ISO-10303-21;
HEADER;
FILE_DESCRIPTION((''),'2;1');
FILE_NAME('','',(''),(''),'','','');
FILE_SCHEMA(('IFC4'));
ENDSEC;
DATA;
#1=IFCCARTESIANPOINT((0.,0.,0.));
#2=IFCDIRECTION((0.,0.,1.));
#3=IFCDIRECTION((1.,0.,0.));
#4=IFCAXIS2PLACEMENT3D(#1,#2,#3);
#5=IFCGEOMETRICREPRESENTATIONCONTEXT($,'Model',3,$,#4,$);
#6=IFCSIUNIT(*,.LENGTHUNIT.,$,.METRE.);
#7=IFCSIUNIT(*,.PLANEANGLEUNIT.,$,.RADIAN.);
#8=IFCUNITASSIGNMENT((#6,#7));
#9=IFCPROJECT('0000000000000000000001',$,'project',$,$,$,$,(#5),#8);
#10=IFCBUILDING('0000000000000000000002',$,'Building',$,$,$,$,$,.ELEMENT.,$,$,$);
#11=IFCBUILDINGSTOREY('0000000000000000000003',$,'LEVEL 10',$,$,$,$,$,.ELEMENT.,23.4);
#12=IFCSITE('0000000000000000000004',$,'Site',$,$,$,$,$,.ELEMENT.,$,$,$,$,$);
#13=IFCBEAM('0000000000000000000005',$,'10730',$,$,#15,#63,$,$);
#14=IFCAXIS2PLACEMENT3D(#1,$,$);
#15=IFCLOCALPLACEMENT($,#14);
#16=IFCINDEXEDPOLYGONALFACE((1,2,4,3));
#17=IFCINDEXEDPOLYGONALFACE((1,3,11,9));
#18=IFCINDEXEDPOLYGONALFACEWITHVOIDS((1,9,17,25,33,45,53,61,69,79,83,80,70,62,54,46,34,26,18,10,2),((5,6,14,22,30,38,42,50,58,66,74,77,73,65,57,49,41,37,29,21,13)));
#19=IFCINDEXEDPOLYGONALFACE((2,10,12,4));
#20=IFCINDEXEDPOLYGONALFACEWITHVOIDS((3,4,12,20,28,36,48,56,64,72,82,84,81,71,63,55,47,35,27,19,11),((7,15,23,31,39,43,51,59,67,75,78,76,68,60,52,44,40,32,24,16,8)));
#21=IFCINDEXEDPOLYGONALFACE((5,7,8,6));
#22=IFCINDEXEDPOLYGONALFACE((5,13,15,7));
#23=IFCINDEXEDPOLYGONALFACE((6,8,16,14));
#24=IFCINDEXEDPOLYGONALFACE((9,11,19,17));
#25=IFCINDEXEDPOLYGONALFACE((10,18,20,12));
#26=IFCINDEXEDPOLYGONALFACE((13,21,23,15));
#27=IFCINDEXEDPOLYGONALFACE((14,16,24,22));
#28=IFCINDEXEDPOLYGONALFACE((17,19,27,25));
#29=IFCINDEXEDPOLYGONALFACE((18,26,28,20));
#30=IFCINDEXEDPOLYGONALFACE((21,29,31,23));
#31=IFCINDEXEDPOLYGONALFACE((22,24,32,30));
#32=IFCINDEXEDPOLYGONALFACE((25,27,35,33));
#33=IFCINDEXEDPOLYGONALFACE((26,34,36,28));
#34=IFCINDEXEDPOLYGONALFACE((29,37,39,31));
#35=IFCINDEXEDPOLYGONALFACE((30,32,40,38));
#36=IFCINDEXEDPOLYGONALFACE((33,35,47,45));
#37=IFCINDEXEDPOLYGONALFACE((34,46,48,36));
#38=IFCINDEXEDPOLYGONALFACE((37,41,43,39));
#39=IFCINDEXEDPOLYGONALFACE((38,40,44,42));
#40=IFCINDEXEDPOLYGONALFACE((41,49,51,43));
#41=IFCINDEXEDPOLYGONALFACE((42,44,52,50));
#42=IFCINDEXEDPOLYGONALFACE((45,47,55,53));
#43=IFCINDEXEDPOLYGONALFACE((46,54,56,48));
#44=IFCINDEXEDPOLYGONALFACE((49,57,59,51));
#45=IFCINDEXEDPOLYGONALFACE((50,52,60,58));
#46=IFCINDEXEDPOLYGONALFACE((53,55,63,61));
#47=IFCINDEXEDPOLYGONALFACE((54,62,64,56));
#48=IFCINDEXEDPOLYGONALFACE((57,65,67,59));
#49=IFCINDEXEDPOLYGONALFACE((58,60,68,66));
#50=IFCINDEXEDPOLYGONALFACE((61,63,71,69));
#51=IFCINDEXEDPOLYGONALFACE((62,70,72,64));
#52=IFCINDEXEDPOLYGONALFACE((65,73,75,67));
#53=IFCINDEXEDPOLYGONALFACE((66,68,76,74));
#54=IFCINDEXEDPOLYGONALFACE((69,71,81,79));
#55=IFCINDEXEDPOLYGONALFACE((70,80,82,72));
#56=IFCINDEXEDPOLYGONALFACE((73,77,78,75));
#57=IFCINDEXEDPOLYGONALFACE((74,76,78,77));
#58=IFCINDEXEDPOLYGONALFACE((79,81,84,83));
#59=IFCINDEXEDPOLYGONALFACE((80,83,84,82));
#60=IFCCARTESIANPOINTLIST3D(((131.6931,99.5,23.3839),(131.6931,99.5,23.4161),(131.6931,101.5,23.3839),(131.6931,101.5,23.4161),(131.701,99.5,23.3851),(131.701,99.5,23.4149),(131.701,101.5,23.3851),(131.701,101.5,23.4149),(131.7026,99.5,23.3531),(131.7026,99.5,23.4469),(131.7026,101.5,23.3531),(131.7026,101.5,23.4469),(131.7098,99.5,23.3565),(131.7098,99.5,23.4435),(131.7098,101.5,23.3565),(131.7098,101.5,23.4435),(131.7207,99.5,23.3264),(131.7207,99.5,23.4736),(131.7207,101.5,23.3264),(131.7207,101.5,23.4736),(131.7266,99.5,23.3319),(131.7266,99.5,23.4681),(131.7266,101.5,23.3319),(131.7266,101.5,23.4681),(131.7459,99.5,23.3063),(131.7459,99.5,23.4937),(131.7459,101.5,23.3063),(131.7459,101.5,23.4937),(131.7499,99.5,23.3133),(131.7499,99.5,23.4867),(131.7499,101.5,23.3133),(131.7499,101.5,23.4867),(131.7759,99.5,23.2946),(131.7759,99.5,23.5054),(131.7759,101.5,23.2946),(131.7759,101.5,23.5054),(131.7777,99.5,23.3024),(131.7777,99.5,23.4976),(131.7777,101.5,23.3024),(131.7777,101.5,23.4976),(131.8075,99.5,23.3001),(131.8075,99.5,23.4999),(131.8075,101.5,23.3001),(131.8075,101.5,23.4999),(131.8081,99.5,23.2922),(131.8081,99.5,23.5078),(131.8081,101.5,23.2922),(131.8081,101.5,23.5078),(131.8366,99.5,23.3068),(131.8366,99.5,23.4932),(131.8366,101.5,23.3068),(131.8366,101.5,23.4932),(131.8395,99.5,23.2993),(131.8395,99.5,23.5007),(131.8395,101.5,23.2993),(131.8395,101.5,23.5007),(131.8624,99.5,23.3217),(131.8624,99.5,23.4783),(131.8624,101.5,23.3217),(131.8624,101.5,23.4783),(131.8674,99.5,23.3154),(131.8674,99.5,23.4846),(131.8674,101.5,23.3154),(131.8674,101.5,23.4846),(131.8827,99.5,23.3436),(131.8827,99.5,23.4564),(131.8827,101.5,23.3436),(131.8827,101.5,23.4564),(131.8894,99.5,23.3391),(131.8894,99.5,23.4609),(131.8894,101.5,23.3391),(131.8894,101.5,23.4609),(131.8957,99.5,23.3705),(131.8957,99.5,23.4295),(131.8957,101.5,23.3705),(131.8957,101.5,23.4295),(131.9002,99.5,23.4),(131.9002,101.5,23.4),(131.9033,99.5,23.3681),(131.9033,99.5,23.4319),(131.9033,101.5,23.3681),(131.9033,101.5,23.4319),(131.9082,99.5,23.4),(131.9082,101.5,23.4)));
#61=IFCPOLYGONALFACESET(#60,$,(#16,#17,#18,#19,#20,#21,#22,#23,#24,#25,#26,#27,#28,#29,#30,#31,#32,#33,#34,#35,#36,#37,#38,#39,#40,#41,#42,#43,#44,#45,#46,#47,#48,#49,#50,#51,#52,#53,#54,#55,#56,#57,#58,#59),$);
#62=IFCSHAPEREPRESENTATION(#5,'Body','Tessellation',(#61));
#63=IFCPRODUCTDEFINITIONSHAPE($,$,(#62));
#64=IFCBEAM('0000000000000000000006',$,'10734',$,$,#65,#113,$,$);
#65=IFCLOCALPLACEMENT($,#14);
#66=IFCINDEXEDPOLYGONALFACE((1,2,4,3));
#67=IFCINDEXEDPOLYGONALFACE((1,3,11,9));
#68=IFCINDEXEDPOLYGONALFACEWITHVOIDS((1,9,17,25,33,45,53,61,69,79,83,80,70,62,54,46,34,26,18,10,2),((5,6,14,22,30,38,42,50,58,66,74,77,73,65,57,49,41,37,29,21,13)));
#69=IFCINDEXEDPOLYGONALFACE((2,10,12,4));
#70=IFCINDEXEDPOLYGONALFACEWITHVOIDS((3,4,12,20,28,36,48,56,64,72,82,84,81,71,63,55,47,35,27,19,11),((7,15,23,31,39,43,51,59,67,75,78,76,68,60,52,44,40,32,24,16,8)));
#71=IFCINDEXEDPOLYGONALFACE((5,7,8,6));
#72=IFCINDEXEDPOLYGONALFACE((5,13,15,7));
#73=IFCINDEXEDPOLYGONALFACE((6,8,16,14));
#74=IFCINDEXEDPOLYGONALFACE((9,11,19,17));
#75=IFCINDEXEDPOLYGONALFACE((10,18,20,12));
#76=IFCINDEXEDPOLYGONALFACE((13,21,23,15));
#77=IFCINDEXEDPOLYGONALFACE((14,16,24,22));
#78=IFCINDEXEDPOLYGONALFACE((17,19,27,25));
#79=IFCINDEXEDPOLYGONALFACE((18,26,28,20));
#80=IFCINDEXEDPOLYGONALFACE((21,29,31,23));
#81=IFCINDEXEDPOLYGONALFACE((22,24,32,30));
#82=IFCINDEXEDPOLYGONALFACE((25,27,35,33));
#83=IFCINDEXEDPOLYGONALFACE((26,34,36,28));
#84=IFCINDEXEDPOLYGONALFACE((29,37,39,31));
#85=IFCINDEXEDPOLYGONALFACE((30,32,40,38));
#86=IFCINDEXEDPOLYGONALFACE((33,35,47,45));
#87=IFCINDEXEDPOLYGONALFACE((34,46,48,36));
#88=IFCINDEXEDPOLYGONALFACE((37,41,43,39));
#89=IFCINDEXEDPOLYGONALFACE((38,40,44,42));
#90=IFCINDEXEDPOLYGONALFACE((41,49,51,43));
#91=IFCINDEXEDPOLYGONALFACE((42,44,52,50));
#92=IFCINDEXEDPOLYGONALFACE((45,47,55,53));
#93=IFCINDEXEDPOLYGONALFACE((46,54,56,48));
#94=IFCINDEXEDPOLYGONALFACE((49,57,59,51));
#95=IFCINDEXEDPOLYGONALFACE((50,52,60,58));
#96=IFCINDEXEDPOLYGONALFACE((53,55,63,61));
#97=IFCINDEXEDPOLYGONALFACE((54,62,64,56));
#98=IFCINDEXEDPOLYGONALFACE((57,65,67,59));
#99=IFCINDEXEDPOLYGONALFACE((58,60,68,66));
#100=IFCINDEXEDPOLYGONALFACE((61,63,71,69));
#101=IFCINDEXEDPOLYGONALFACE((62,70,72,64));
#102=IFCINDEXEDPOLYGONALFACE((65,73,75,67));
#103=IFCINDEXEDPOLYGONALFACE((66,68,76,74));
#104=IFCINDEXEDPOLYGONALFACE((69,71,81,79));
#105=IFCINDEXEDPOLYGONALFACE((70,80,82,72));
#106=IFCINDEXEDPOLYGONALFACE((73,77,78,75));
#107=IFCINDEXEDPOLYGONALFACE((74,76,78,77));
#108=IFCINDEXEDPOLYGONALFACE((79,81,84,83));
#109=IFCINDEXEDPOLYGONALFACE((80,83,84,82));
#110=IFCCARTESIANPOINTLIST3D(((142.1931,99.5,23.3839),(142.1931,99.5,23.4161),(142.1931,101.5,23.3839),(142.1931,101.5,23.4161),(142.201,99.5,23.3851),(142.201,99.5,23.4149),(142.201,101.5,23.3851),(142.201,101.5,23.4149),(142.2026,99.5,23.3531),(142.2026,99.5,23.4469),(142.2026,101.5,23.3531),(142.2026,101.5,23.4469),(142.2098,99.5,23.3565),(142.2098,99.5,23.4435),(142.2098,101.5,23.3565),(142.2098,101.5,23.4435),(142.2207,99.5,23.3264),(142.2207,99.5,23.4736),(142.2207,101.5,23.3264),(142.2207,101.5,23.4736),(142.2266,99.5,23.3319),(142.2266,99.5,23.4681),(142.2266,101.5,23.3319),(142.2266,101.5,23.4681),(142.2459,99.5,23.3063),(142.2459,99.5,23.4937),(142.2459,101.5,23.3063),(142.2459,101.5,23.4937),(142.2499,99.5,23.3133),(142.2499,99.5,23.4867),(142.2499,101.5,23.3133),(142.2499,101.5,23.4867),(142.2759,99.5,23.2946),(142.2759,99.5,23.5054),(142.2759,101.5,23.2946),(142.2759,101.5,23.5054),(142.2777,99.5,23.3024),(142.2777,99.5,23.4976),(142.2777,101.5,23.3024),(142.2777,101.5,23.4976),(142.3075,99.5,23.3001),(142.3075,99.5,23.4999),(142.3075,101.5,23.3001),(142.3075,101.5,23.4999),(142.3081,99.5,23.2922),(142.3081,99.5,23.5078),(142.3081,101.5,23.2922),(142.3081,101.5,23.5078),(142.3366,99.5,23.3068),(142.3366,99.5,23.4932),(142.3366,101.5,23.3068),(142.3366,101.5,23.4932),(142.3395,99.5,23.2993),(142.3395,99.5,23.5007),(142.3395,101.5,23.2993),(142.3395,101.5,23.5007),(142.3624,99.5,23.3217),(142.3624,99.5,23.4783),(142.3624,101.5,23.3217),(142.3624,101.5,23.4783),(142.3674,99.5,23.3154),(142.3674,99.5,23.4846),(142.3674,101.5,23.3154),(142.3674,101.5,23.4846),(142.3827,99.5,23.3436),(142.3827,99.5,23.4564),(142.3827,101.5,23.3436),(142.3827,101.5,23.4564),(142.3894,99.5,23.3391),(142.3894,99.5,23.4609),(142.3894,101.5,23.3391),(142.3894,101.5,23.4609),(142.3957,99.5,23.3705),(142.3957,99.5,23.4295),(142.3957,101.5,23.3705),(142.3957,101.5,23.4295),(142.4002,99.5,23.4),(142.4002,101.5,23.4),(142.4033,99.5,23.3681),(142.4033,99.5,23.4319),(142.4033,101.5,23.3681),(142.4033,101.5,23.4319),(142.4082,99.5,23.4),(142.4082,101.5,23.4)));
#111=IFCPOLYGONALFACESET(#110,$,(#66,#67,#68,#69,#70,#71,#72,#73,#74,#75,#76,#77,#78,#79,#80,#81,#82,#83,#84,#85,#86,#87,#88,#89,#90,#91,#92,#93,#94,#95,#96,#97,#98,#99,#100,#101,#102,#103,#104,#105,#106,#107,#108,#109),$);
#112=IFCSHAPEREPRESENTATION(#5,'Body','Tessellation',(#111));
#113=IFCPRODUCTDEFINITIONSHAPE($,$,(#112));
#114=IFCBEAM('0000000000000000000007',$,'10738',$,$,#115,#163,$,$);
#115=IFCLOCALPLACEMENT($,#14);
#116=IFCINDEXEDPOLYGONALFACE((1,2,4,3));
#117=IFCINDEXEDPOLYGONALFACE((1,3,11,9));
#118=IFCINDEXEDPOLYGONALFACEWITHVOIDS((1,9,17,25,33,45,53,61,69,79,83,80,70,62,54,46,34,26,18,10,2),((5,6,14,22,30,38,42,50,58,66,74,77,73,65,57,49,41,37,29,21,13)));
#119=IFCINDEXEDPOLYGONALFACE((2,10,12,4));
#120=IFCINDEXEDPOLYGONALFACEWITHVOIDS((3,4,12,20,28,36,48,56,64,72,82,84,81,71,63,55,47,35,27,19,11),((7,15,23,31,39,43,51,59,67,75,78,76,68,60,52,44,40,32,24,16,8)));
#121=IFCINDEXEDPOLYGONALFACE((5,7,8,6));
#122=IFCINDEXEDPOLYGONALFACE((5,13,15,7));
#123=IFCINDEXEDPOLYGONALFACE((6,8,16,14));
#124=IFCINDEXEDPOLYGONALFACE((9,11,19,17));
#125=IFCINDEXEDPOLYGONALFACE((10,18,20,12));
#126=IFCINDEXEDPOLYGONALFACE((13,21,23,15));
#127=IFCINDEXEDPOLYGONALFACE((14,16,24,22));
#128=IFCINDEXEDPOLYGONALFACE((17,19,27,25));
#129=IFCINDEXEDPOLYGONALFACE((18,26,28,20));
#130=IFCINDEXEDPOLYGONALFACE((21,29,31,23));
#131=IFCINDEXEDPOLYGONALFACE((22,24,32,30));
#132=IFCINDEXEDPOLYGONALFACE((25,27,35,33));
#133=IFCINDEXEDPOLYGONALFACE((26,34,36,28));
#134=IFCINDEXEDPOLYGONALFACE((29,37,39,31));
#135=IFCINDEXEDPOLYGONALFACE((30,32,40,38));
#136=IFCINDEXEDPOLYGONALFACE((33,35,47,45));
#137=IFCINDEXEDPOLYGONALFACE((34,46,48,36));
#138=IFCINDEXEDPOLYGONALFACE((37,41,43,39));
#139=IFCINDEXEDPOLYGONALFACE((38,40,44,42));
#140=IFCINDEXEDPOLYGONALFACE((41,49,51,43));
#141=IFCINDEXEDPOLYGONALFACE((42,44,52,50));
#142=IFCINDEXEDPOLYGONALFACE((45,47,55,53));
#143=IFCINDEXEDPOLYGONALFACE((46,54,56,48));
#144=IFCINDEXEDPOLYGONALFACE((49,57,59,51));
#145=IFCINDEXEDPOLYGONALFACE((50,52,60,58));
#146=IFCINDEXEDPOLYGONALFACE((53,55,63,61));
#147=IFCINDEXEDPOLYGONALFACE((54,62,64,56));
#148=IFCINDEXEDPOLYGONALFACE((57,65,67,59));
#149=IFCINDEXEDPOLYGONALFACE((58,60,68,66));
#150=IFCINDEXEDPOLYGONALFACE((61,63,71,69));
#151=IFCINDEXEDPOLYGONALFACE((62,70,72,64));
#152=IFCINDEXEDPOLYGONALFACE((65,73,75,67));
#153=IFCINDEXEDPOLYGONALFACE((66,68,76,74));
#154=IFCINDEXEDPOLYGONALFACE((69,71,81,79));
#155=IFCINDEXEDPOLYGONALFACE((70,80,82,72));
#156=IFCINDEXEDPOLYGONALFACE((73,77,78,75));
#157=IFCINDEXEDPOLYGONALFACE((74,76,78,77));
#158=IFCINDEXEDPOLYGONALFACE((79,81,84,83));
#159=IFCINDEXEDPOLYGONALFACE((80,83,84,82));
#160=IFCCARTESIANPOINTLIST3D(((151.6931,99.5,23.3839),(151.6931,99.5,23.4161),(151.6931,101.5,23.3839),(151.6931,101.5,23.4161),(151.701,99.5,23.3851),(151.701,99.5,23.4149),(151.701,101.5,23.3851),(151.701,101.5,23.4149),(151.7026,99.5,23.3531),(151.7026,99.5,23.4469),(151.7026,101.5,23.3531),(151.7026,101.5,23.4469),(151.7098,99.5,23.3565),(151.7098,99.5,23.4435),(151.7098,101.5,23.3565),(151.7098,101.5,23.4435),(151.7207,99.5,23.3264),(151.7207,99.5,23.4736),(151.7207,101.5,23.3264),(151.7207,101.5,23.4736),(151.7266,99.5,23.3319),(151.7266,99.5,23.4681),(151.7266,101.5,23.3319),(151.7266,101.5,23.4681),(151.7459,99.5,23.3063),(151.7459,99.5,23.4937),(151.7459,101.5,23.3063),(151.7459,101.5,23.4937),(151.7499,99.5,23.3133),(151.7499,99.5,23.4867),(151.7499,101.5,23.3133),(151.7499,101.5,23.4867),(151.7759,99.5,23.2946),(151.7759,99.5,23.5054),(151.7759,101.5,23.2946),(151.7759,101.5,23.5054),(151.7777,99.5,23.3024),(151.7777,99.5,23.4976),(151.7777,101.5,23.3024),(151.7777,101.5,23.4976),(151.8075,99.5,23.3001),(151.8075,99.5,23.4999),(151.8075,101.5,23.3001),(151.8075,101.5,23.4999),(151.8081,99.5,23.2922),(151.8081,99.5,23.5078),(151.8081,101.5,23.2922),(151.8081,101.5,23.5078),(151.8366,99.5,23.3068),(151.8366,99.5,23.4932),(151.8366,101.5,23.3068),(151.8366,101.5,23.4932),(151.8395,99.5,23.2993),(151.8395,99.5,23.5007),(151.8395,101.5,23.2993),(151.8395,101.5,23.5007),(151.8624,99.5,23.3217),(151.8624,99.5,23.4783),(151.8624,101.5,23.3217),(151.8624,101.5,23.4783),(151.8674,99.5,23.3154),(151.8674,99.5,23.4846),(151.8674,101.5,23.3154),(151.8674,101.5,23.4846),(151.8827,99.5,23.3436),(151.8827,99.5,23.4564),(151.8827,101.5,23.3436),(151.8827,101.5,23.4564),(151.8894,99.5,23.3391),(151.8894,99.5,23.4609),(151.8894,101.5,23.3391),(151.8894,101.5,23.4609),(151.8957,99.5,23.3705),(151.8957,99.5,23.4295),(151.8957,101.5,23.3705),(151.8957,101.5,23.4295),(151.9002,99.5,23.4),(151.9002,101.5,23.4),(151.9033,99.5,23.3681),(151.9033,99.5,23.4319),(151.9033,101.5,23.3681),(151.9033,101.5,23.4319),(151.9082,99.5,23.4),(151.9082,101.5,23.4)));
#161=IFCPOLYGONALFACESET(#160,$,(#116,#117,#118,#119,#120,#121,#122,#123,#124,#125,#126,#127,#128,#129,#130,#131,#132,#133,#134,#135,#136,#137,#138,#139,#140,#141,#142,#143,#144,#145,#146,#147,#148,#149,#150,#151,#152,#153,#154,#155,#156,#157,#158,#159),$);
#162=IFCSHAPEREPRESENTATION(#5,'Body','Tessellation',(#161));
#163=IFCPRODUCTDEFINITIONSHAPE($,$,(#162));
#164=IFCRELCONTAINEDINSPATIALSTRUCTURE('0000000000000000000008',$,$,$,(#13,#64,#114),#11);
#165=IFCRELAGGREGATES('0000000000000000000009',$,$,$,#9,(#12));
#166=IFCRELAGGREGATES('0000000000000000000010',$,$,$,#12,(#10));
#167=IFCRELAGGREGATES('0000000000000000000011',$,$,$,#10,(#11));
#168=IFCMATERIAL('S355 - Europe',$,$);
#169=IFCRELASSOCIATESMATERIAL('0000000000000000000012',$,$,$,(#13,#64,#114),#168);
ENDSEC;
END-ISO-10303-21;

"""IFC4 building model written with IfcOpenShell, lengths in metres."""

from ifc_helpers import new_model, si_unit, frame, origin_with_axes, origin_2d_with_axis, place, context, project, spatial, hollow_circle, extrude, material, material_profile, profile_set, profile_usage, element, save


model = new_model("IFC4")

# Units and contexts
model_context = context("Model", 3, world=origin_with_axes())
ifc_project = project(units=[si_unit("LENGTHUNIT", "METRE"), si_unit("PLANEANGLEUNIT", "RADIAN")], contexts=[model_context])

# Site, building, storey
site = spatial("IfcSite", under=ifc_project, Name="Site", CompositionType="ELEMENT")
building = spatial("IfcBuilding", under=site, Name="Building", CompositionType="ELEMENT")
storey = spatial("IfcBuildingStorey", under=building, Name="LEVEL 10", CompositionType="ELEMENT", Elevation=23.4)

# Shared definitions
ifc_material = material(Name="S355 - Europe")

# Beams
ifc_material_profile_1 = material_profile(ifc_material, hollow_circle(Radius=0.1081, WallThickness=0.008, at=origin_2d_with_axis()))
ifc_profile_set_1 = profile_set([ifc_material_profile_1])
ifc_profile_usage_1 = profile_usage(ifc_profile_set_1, cardinal=10)
beam_1_placement = place(None, frame((131.8, 101.5, 23.4), z_axis=(0.0, -1.0, 0.0), x_axis=(1.0, 0.0, 0.0)))
element("IfcBeam", 1, at=beam_1_placement, inside=storey, material=ifc_profile_usage_1, Name="10730", context=model_context, shape_type="SweptSolid", body=[
    extrude(hollow_circle(Radius=0.1081, WallThickness=0.008, at=origin_2d_with_axis()), origin_with_axes(), (0.0, 0.0, 1.0), 2.0),
])
ifc_material_profile_2 = material_profile(ifc_material, hollow_circle(Radius=0.1081, WallThickness=0.008, at=origin_2d_with_axis()))
ifc_profile_set_2 = profile_set([ifc_material_profile_2])
ifc_profile_usage_2 = profile_usage(ifc_profile_set_2, cardinal=10)
beam_2_placement = place(None, frame((142.3, 101.5, 23.4), z_axis=(0.0, -1.0, 0.0), x_axis=(1.0, 0.0, 0.0)))
element("IfcBeam", 2, at=beam_2_placement, inside=storey, material=ifc_profile_usage_2, Name="10734", context=model_context, shape_type="SweptSolid", body=[
    extrude(hollow_circle(Radius=0.1081, WallThickness=0.008, at=origin_2d_with_axis()), origin_with_axes(), (0.0, 0.0, 1.0), 2.0),
])
ifc_material_profile_3 = material_profile(ifc_material, hollow_circle(Radius=0.1081, WallThickness=0.008, at=origin_2d_with_axis()))
ifc_profile_set_3 = profile_set([ifc_material_profile_3])
ifc_profile_usage_3 = profile_usage(ifc_profile_set_3, cardinal=10)
beam_3_placement = place(None, frame((151.8, 101.5, 23.4), z_axis=(0.0, -1.0, 0.0), x_axis=(1.0, 0.0, 0.0)))
element("IfcBeam", 3, at=beam_3_placement, inside=storey, material=ifc_profile_usage_3, Name="10738", context=model_context, shape_type="SweptSolid", body=[
    extrude(hollow_circle(Radius=0.1081, WallThickness=0.008, at=origin_2d_with_axis()), origin_with_axes(), (0.0, 0.0, 1.0), 2.0),
])

save(model, "model.ifc")
